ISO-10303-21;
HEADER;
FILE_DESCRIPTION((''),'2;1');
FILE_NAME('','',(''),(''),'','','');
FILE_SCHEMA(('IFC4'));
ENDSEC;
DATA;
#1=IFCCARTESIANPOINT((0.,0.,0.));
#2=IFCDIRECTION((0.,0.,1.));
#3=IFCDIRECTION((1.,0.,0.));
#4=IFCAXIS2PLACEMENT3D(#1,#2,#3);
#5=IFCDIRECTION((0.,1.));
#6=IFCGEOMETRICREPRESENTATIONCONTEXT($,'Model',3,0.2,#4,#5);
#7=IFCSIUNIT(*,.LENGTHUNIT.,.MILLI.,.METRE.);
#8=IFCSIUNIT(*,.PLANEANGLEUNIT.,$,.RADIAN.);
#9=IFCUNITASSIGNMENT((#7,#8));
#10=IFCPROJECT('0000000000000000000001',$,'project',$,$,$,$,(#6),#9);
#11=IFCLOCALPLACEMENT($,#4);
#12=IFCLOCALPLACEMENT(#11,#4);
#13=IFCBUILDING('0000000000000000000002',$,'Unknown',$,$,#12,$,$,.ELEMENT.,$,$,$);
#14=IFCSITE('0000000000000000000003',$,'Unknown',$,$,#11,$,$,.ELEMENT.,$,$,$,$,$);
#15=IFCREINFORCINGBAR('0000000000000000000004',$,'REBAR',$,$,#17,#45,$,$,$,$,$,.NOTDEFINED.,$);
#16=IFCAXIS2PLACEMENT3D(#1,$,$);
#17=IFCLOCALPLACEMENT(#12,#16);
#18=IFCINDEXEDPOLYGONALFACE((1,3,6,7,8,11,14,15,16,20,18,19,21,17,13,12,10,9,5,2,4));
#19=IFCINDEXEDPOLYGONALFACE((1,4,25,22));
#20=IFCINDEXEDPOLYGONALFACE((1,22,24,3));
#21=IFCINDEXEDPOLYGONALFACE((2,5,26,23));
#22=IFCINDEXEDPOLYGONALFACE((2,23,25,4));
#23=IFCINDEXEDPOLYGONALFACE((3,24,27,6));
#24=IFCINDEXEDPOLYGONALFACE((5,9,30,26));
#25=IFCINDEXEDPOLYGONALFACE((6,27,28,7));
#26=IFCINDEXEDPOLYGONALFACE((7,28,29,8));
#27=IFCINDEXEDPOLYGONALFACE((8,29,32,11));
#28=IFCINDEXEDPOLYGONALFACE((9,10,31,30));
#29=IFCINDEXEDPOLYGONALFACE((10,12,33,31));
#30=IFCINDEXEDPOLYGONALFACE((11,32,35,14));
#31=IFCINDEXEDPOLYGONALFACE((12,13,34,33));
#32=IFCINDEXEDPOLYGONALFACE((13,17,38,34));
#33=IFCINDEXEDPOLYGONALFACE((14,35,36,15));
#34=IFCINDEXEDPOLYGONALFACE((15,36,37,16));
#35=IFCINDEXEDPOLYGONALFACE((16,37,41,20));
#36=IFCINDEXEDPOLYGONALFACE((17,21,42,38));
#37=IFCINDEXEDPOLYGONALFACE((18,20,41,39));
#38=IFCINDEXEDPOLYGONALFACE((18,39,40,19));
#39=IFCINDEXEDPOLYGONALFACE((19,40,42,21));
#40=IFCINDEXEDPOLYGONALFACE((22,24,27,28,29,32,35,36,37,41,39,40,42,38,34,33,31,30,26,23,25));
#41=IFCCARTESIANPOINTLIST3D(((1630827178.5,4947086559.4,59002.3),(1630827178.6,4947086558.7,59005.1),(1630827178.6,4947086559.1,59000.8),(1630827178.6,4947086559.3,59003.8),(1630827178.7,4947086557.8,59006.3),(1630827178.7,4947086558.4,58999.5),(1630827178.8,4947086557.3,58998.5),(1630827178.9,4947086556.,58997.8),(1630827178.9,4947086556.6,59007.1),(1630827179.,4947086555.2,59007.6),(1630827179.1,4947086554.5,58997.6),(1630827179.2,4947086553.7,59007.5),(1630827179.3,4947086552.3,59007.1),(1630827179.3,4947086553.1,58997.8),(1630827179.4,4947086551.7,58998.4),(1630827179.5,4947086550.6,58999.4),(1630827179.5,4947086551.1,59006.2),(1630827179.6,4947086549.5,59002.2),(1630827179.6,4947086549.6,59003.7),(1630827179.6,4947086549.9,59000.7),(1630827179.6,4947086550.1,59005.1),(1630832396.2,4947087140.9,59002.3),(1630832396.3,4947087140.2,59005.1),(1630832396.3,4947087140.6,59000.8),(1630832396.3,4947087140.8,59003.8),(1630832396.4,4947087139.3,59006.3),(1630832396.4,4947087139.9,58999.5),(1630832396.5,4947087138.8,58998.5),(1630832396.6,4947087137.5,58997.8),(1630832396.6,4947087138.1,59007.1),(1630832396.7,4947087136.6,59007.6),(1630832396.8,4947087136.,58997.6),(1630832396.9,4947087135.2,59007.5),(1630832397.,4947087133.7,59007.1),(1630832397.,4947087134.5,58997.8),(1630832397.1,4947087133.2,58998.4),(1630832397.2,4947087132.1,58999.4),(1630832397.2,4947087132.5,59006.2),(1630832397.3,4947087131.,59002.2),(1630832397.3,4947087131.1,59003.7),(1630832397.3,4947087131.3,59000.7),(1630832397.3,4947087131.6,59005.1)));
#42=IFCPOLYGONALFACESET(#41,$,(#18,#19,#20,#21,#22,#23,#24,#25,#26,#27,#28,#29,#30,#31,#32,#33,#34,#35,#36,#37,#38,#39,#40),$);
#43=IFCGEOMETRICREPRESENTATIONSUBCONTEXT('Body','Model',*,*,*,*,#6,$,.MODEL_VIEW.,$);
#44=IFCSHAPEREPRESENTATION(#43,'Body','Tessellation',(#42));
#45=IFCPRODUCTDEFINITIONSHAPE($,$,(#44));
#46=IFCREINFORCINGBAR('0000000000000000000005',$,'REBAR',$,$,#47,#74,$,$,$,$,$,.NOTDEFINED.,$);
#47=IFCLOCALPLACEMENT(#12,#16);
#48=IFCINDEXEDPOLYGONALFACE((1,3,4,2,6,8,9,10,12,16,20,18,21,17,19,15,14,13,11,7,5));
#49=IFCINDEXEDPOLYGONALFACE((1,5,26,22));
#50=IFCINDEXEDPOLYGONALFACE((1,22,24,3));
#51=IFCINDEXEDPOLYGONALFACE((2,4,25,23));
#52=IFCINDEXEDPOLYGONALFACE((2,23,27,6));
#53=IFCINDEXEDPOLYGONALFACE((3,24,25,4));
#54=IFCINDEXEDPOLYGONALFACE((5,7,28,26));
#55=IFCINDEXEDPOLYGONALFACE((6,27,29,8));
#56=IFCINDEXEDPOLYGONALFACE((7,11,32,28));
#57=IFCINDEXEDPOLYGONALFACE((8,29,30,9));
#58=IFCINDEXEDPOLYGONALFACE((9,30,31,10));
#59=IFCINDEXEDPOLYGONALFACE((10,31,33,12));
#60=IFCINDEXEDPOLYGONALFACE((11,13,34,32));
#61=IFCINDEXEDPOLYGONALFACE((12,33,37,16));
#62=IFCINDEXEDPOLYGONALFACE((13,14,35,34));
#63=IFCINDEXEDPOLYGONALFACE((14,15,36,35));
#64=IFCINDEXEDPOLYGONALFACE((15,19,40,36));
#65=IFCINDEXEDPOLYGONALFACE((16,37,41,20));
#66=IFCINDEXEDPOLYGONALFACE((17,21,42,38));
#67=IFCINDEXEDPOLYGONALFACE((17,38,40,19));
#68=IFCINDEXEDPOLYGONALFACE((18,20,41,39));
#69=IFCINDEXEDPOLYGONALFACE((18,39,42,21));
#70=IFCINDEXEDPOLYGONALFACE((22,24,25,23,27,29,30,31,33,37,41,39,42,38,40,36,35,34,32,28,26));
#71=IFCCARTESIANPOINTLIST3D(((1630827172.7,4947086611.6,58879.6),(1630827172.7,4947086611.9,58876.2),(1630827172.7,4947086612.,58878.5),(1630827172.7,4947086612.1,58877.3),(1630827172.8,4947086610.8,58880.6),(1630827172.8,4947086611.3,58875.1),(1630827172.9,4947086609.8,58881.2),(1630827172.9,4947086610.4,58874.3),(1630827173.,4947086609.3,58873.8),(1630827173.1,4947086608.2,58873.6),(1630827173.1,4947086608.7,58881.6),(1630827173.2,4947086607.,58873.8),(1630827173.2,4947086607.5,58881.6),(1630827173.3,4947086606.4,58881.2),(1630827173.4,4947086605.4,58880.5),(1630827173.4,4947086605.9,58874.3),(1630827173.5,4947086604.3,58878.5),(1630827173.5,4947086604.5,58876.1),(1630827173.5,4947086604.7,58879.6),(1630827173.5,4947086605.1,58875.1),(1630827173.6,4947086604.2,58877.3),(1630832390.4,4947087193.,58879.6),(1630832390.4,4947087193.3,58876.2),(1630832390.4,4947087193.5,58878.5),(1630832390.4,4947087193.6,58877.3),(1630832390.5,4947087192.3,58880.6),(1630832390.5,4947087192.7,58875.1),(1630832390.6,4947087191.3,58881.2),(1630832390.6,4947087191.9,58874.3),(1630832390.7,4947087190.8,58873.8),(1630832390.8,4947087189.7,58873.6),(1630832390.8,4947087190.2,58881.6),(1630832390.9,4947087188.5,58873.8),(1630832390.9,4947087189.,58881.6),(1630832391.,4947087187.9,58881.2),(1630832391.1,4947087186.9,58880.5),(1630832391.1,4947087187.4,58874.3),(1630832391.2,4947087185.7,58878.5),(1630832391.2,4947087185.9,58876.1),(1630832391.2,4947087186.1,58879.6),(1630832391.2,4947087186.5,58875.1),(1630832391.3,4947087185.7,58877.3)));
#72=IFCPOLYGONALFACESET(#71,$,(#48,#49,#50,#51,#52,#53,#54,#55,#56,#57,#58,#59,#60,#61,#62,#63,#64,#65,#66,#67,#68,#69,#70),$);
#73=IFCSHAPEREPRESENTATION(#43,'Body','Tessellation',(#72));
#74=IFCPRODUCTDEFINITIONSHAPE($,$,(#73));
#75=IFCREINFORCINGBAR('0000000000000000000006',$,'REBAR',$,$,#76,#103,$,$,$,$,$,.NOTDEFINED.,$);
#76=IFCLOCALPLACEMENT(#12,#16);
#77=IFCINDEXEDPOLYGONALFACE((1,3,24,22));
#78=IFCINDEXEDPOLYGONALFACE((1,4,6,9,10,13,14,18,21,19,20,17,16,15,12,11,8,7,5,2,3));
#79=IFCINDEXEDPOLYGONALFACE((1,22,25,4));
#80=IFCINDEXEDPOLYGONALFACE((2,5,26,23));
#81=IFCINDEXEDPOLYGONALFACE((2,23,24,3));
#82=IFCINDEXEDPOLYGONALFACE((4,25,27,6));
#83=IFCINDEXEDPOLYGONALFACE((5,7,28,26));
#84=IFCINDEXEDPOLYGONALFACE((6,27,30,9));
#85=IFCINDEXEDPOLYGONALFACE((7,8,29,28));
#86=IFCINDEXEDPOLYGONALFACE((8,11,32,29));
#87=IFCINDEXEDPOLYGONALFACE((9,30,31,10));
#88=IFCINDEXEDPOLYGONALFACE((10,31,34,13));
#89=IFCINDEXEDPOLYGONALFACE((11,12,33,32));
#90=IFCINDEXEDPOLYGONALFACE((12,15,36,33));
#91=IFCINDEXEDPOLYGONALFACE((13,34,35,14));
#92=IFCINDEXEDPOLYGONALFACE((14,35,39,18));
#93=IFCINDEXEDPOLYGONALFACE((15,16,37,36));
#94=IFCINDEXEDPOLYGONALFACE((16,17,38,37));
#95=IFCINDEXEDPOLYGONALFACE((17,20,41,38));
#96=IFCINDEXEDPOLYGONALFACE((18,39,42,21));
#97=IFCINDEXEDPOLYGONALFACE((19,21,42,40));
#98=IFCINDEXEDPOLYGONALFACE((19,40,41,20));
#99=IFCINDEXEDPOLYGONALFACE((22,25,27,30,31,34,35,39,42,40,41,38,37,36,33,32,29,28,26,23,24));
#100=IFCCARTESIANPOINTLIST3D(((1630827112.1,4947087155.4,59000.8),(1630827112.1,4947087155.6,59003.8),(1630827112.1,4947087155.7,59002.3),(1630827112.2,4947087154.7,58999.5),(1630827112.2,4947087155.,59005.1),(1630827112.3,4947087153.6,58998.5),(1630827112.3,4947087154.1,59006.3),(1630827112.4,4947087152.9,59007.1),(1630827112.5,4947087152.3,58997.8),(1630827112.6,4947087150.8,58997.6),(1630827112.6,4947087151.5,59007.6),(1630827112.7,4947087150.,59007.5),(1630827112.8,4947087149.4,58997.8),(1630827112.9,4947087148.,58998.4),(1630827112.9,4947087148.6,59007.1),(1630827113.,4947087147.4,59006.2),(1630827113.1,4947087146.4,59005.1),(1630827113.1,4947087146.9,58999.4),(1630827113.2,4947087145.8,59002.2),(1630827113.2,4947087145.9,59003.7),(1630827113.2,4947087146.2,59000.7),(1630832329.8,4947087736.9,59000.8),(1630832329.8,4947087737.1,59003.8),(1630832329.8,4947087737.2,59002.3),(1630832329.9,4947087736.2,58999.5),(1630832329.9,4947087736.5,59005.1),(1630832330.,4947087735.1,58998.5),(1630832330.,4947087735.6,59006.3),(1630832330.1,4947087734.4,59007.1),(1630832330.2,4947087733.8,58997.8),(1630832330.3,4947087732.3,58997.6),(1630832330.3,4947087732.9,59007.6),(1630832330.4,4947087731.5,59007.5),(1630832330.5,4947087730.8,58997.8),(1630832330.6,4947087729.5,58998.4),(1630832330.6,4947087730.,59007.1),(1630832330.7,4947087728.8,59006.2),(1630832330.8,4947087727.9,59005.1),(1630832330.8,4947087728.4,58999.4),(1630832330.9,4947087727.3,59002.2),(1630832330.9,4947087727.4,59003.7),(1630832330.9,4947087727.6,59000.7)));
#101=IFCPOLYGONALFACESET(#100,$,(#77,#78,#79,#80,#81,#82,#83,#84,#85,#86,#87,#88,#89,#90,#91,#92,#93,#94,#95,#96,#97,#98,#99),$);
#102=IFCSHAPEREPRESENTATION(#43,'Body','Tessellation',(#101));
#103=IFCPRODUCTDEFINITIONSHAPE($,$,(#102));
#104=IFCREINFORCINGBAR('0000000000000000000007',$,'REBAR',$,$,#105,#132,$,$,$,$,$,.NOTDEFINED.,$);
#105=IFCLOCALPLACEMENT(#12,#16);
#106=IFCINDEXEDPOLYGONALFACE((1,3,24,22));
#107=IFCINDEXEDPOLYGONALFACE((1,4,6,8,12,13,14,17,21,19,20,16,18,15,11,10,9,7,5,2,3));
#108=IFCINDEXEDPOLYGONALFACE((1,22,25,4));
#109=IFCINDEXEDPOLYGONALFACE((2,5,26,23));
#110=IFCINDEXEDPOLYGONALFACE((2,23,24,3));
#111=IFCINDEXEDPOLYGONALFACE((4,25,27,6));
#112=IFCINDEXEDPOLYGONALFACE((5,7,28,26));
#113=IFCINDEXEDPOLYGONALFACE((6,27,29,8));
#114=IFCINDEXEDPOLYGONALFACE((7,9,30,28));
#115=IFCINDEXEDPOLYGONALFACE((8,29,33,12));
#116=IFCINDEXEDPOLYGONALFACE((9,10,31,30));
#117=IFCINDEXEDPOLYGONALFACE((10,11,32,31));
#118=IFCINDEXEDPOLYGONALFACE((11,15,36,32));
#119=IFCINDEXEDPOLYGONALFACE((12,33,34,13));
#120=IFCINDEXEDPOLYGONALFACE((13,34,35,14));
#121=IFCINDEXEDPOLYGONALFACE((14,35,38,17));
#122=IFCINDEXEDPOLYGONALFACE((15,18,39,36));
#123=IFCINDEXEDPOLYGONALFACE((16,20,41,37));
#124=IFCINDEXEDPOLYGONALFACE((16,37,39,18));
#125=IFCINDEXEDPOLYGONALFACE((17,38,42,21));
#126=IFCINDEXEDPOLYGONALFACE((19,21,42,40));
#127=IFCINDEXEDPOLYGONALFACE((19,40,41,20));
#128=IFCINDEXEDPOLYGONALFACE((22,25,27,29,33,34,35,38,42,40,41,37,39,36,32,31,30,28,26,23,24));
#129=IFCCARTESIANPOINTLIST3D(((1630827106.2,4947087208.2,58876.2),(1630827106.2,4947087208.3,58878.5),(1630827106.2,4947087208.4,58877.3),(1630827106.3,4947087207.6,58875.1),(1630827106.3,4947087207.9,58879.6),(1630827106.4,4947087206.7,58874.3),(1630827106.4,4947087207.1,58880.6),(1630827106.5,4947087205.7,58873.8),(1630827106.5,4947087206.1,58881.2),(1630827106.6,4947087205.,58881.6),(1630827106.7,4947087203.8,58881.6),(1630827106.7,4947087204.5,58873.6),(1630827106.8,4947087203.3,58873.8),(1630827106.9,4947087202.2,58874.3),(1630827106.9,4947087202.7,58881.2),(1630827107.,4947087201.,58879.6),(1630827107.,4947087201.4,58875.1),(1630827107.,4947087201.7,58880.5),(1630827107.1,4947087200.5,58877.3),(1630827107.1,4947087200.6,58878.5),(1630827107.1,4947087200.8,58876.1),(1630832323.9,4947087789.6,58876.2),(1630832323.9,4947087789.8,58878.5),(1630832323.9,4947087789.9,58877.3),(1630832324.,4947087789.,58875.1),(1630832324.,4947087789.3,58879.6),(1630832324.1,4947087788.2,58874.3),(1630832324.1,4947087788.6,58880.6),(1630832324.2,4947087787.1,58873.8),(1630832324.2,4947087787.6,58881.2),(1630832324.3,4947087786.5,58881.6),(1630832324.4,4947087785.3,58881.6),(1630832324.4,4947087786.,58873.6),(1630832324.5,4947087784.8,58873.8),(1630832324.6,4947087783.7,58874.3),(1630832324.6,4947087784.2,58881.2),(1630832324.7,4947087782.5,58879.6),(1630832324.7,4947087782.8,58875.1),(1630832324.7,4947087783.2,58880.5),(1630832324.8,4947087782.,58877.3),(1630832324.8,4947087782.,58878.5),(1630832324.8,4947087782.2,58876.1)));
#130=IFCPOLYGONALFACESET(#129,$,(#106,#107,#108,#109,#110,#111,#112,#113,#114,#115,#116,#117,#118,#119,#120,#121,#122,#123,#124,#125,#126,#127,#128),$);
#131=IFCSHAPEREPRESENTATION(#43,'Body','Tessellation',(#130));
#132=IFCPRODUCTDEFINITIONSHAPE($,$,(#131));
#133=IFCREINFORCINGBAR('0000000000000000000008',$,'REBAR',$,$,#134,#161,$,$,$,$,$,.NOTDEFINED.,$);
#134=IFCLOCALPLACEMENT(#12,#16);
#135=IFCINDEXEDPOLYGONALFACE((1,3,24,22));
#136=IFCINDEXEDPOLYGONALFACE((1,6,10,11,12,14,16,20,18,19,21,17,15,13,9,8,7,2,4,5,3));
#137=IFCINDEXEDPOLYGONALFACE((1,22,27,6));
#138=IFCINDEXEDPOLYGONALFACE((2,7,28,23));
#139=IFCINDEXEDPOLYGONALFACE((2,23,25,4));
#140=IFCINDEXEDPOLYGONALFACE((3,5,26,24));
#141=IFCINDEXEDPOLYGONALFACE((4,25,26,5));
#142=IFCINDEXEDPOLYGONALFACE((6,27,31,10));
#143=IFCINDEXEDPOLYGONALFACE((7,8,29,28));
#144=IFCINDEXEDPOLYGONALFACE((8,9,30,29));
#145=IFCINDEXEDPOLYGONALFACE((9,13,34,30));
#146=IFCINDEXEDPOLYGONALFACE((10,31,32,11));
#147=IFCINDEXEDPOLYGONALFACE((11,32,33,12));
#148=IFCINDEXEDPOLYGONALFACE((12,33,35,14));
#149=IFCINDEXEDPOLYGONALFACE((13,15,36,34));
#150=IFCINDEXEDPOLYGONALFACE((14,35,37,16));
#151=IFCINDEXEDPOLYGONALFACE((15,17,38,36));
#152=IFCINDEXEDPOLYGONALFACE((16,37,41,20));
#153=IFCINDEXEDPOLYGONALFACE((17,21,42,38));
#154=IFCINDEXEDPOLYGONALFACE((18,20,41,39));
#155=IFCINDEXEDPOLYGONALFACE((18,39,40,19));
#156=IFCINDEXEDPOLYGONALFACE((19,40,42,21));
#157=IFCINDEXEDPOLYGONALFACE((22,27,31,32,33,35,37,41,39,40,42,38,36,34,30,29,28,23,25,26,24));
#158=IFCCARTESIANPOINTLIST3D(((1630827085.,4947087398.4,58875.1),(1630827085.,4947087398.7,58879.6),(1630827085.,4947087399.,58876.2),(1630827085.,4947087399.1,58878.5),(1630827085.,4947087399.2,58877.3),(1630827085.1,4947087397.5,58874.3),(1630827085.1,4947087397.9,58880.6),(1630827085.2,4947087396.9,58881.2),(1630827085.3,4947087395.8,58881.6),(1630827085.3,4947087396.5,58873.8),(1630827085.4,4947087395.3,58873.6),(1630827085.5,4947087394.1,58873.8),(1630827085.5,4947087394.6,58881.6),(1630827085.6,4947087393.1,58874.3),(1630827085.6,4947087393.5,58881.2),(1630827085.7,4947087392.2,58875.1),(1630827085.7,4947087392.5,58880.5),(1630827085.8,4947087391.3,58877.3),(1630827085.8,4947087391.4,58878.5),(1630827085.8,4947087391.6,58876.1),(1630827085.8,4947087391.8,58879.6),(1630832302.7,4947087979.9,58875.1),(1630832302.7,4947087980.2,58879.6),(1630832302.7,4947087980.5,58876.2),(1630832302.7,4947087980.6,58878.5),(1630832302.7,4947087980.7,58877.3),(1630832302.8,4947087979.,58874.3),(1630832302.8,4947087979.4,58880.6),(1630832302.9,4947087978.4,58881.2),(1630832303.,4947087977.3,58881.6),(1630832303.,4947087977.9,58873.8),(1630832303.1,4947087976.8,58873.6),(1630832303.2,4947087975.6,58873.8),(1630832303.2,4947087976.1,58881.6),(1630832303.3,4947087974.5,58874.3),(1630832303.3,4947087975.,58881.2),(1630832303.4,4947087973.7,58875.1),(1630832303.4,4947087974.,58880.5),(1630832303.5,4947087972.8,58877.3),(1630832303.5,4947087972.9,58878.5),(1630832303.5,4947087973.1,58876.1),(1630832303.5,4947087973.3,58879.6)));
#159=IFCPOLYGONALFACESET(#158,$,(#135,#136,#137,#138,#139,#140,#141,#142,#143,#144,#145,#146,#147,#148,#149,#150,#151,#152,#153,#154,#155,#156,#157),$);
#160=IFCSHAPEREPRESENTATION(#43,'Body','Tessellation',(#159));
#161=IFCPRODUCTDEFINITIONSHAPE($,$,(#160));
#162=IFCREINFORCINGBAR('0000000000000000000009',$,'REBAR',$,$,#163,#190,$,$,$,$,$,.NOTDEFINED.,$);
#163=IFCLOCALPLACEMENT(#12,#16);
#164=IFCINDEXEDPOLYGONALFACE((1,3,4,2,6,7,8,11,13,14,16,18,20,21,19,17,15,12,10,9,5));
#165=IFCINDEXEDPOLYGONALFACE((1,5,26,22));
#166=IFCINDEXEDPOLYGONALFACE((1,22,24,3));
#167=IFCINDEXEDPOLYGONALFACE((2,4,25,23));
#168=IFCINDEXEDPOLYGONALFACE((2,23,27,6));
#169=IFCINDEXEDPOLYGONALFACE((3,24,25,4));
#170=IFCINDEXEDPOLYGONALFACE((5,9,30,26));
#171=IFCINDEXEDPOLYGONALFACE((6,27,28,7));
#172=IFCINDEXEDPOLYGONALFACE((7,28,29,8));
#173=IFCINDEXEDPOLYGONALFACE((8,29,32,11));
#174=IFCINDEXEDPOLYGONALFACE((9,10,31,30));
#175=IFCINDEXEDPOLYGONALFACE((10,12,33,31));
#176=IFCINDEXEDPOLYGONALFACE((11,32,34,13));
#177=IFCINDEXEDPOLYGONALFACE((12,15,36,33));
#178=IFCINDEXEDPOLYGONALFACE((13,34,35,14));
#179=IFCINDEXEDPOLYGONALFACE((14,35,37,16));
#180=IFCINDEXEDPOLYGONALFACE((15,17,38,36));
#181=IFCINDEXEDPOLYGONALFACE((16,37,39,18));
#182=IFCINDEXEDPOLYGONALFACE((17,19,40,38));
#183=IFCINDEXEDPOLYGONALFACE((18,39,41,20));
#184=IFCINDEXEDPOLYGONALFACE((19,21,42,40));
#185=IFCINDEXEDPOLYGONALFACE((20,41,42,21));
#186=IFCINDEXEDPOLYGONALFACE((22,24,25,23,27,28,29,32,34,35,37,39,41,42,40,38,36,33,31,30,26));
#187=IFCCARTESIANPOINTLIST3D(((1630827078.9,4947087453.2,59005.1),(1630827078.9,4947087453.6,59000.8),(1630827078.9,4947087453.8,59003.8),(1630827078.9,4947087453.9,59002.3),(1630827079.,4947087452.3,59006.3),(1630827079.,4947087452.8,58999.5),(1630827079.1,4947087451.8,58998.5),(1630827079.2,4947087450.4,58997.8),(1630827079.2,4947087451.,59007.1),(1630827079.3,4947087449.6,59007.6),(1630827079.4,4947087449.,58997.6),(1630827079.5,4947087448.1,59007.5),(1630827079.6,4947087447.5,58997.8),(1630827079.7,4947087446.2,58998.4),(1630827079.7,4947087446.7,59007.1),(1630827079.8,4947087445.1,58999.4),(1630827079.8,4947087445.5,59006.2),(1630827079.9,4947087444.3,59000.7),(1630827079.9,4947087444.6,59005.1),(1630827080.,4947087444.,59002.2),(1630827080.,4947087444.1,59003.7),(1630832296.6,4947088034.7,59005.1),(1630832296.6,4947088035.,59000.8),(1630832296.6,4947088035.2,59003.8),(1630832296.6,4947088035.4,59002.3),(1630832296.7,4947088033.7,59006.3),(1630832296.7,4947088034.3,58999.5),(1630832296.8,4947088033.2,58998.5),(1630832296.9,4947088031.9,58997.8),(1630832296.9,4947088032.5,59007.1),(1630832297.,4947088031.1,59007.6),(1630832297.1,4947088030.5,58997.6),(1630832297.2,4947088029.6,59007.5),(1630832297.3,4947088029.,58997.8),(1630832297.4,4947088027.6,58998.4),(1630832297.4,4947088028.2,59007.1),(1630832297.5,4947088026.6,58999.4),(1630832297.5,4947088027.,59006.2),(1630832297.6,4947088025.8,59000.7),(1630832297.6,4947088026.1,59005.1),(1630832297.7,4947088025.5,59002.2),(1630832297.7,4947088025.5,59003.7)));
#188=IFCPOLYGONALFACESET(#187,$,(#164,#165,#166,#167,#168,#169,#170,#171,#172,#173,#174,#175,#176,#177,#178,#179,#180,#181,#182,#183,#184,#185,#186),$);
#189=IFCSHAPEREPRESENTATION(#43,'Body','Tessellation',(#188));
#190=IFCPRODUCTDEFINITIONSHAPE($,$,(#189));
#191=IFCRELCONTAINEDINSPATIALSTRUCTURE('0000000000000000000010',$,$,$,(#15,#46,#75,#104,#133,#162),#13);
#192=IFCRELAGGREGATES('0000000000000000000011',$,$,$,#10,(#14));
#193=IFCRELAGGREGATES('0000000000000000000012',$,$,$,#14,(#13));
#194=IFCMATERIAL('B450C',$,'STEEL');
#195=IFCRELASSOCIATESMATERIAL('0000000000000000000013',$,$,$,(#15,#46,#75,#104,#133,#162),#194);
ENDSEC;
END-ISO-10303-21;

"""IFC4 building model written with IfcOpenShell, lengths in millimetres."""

from ifc_helpers import new_model, entity, si_unit, direction, frame, origin_with_axes, place, context, subcontext, project, spatial, material, element, save


model = new_model("IFC4")

# Units and contexts
model_context = context("Model", 3, precision=0.2, world=origin_with_axes(), true_north=direction((0.0, 1.0)))
body_context = subcontext(model_context, "Body", "Model", "MODEL_VIEW")
ifc_project = project(units=[si_unit("LENGTHUNIT", "METRE", prefix="MILLI"), si_unit("PLANEANGLEUNIT", "RADIAN")], contexts=[model_context])

# Site, building
site_placement = place(None, origin_with_axes())
site = spatial("IfcSite", under=ifc_project, at=site_placement, Name="Unknown", CompositionType="ELEMENT")
building_placement = place(site_placement, origin_with_axes())
building = spatial("IfcBuilding", under=site, at=building_placement, Name="Unknown", CompositionType="ELEMENT")

# Reinforcing bars
ifc_material = material(Name="B450C", Category="STEEL")
reinforcing_bar_1_placement = place(building_placement, frame((1630832396.8, 4947087135.9, 59002.6), z_axis=(0.007106, -0.063762, -0.99794), x_axis=(-0.993847, -0.110757, 0.0)))
element("IfcReinforcingBar", 1, at=reinforcing_bar_1_placement, inside=building, material=ifc_material, Name="REBAR", PredefinedType="NOTDEFINED", context=body_context, shape_type="AdvancedSweptSolid", body=[
    entity("IfcSweptDiskSolid", entity("IfcIndexedPolyCurve", entity("IfcCartesianPointList3D", [[0.0, 0.0, 0.0], [5250.0, 0.0, 0.0]]), [entity("IfcLineIndex", [1, 2])]), 5.0),
])
reinforcing_bar_2_placement = place(building_placement, frame((1630832390.8, 4947087189.6, 58877.6), z_axis=(0.007106, -0.063762, -0.99794), x_axis=(-0.993847, -0.110757, 0.0)))
element("IfcReinforcingBar", 2, at=reinforcing_bar_2_placement, inside=building, material=ifc_material, Name="REBAR", PredefinedType="NOTDEFINED", context=body_context, shape_type="AdvancedSweptSolid", body=[
    entity("IfcSweptDiskSolid", entity("IfcIndexedPolyCurve", entity("IfcCartesianPointList3D", [[0.0, 0.0, 0.0], [5250.0, 0.0, 0.0]]), [entity("IfcLineIndex", [1, 2])]), 4.0),
])
reinforcing_bar_3_placement = place(building_placement, frame((1630832330.3, 4947087732.2, 59002.6), z_axis=(0.007106, -0.063762, -0.99794), x_axis=(-0.993847, -0.110757, 0.0)))
element("IfcReinforcingBar", 3, at=reinforcing_bar_3_placement, inside=building, material=ifc_material, Name="REBAR", PredefinedType="NOTDEFINED", context=body_context, shape_type="AdvancedSweptSolid", body=[
    entity("IfcSweptDiskSolid", entity("IfcIndexedPolyCurve", entity("IfcCartesianPointList3D", [[0.0, 0.0, 0.0], [5250.0, 0.0, 0.0]]), [entity("IfcLineIndex", [1, 2])]), 5.0),
])
reinforcing_bar_4_placement = place(building_placement, frame((1630832324.4, 4947087785.9, 58877.6), z_axis=(0.007106, -0.063762, -0.99794), x_axis=(-0.993847, -0.110757, 0.0)))
element("IfcReinforcingBar", 4, at=reinforcing_bar_4_placement, inside=building, material=ifc_material, Name="REBAR", PredefinedType="NOTDEFINED", context=body_context, shape_type="AdvancedSweptSolid", body=[
    entity("IfcSweptDiskSolid", entity("IfcIndexedPolyCurve", entity("IfcCartesianPointList3D", [[0.0, 0.0, 0.0], [5250.0, 0.0, 0.0]]), [entity("IfcLineIndex", [1, 2])]), 4.0),
])
reinforcing_bar_5_placement = place(building_placement, frame((1630832303.1, 4947087976.7, 58877.6), z_axis=(0.007106, -0.063762, -0.99794), x_axis=(-0.993847, -0.110757, 0.0)))
element("IfcReinforcingBar", 5, at=reinforcing_bar_5_placement, inside=building, material=ifc_material, Name="REBAR", PredefinedType="NOTDEFINED", context=body_context, shape_type="AdvancedSweptSolid", body=[
    entity("IfcSweptDiskSolid", entity("IfcIndexedPolyCurve", entity("IfcCartesianPointList3D", [[0.0, 0.0, 0.0], [5250.0, 0.0, 0.0]]), [entity("IfcLineIndex", [1, 2])]), 4.0),
])
reinforcing_bar_6_placement = place(building_placement, frame((1630832297.1, 4947088030.4, 59002.6), z_axis=(0.007106, -0.063762, -0.99794), x_axis=(-0.993847, -0.110757, 0.0)))
element("IfcReinforcingBar", 6, at=reinforcing_bar_6_placement, inside=building, material=ifc_material, Name="REBAR", PredefinedType="NOTDEFINED", context=body_context, shape_type="AdvancedSweptSolid", body=[
    entity("IfcSweptDiskSolid", entity("IfcIndexedPolyCurve", entity("IfcCartesianPointList3D", [[0.0, 0.0, 0.0], [5250.0, 0.0, 0.0]]), [entity("IfcLineIndex", [1, 2])]), 5.0),
])

save(model, "model.ifc")
